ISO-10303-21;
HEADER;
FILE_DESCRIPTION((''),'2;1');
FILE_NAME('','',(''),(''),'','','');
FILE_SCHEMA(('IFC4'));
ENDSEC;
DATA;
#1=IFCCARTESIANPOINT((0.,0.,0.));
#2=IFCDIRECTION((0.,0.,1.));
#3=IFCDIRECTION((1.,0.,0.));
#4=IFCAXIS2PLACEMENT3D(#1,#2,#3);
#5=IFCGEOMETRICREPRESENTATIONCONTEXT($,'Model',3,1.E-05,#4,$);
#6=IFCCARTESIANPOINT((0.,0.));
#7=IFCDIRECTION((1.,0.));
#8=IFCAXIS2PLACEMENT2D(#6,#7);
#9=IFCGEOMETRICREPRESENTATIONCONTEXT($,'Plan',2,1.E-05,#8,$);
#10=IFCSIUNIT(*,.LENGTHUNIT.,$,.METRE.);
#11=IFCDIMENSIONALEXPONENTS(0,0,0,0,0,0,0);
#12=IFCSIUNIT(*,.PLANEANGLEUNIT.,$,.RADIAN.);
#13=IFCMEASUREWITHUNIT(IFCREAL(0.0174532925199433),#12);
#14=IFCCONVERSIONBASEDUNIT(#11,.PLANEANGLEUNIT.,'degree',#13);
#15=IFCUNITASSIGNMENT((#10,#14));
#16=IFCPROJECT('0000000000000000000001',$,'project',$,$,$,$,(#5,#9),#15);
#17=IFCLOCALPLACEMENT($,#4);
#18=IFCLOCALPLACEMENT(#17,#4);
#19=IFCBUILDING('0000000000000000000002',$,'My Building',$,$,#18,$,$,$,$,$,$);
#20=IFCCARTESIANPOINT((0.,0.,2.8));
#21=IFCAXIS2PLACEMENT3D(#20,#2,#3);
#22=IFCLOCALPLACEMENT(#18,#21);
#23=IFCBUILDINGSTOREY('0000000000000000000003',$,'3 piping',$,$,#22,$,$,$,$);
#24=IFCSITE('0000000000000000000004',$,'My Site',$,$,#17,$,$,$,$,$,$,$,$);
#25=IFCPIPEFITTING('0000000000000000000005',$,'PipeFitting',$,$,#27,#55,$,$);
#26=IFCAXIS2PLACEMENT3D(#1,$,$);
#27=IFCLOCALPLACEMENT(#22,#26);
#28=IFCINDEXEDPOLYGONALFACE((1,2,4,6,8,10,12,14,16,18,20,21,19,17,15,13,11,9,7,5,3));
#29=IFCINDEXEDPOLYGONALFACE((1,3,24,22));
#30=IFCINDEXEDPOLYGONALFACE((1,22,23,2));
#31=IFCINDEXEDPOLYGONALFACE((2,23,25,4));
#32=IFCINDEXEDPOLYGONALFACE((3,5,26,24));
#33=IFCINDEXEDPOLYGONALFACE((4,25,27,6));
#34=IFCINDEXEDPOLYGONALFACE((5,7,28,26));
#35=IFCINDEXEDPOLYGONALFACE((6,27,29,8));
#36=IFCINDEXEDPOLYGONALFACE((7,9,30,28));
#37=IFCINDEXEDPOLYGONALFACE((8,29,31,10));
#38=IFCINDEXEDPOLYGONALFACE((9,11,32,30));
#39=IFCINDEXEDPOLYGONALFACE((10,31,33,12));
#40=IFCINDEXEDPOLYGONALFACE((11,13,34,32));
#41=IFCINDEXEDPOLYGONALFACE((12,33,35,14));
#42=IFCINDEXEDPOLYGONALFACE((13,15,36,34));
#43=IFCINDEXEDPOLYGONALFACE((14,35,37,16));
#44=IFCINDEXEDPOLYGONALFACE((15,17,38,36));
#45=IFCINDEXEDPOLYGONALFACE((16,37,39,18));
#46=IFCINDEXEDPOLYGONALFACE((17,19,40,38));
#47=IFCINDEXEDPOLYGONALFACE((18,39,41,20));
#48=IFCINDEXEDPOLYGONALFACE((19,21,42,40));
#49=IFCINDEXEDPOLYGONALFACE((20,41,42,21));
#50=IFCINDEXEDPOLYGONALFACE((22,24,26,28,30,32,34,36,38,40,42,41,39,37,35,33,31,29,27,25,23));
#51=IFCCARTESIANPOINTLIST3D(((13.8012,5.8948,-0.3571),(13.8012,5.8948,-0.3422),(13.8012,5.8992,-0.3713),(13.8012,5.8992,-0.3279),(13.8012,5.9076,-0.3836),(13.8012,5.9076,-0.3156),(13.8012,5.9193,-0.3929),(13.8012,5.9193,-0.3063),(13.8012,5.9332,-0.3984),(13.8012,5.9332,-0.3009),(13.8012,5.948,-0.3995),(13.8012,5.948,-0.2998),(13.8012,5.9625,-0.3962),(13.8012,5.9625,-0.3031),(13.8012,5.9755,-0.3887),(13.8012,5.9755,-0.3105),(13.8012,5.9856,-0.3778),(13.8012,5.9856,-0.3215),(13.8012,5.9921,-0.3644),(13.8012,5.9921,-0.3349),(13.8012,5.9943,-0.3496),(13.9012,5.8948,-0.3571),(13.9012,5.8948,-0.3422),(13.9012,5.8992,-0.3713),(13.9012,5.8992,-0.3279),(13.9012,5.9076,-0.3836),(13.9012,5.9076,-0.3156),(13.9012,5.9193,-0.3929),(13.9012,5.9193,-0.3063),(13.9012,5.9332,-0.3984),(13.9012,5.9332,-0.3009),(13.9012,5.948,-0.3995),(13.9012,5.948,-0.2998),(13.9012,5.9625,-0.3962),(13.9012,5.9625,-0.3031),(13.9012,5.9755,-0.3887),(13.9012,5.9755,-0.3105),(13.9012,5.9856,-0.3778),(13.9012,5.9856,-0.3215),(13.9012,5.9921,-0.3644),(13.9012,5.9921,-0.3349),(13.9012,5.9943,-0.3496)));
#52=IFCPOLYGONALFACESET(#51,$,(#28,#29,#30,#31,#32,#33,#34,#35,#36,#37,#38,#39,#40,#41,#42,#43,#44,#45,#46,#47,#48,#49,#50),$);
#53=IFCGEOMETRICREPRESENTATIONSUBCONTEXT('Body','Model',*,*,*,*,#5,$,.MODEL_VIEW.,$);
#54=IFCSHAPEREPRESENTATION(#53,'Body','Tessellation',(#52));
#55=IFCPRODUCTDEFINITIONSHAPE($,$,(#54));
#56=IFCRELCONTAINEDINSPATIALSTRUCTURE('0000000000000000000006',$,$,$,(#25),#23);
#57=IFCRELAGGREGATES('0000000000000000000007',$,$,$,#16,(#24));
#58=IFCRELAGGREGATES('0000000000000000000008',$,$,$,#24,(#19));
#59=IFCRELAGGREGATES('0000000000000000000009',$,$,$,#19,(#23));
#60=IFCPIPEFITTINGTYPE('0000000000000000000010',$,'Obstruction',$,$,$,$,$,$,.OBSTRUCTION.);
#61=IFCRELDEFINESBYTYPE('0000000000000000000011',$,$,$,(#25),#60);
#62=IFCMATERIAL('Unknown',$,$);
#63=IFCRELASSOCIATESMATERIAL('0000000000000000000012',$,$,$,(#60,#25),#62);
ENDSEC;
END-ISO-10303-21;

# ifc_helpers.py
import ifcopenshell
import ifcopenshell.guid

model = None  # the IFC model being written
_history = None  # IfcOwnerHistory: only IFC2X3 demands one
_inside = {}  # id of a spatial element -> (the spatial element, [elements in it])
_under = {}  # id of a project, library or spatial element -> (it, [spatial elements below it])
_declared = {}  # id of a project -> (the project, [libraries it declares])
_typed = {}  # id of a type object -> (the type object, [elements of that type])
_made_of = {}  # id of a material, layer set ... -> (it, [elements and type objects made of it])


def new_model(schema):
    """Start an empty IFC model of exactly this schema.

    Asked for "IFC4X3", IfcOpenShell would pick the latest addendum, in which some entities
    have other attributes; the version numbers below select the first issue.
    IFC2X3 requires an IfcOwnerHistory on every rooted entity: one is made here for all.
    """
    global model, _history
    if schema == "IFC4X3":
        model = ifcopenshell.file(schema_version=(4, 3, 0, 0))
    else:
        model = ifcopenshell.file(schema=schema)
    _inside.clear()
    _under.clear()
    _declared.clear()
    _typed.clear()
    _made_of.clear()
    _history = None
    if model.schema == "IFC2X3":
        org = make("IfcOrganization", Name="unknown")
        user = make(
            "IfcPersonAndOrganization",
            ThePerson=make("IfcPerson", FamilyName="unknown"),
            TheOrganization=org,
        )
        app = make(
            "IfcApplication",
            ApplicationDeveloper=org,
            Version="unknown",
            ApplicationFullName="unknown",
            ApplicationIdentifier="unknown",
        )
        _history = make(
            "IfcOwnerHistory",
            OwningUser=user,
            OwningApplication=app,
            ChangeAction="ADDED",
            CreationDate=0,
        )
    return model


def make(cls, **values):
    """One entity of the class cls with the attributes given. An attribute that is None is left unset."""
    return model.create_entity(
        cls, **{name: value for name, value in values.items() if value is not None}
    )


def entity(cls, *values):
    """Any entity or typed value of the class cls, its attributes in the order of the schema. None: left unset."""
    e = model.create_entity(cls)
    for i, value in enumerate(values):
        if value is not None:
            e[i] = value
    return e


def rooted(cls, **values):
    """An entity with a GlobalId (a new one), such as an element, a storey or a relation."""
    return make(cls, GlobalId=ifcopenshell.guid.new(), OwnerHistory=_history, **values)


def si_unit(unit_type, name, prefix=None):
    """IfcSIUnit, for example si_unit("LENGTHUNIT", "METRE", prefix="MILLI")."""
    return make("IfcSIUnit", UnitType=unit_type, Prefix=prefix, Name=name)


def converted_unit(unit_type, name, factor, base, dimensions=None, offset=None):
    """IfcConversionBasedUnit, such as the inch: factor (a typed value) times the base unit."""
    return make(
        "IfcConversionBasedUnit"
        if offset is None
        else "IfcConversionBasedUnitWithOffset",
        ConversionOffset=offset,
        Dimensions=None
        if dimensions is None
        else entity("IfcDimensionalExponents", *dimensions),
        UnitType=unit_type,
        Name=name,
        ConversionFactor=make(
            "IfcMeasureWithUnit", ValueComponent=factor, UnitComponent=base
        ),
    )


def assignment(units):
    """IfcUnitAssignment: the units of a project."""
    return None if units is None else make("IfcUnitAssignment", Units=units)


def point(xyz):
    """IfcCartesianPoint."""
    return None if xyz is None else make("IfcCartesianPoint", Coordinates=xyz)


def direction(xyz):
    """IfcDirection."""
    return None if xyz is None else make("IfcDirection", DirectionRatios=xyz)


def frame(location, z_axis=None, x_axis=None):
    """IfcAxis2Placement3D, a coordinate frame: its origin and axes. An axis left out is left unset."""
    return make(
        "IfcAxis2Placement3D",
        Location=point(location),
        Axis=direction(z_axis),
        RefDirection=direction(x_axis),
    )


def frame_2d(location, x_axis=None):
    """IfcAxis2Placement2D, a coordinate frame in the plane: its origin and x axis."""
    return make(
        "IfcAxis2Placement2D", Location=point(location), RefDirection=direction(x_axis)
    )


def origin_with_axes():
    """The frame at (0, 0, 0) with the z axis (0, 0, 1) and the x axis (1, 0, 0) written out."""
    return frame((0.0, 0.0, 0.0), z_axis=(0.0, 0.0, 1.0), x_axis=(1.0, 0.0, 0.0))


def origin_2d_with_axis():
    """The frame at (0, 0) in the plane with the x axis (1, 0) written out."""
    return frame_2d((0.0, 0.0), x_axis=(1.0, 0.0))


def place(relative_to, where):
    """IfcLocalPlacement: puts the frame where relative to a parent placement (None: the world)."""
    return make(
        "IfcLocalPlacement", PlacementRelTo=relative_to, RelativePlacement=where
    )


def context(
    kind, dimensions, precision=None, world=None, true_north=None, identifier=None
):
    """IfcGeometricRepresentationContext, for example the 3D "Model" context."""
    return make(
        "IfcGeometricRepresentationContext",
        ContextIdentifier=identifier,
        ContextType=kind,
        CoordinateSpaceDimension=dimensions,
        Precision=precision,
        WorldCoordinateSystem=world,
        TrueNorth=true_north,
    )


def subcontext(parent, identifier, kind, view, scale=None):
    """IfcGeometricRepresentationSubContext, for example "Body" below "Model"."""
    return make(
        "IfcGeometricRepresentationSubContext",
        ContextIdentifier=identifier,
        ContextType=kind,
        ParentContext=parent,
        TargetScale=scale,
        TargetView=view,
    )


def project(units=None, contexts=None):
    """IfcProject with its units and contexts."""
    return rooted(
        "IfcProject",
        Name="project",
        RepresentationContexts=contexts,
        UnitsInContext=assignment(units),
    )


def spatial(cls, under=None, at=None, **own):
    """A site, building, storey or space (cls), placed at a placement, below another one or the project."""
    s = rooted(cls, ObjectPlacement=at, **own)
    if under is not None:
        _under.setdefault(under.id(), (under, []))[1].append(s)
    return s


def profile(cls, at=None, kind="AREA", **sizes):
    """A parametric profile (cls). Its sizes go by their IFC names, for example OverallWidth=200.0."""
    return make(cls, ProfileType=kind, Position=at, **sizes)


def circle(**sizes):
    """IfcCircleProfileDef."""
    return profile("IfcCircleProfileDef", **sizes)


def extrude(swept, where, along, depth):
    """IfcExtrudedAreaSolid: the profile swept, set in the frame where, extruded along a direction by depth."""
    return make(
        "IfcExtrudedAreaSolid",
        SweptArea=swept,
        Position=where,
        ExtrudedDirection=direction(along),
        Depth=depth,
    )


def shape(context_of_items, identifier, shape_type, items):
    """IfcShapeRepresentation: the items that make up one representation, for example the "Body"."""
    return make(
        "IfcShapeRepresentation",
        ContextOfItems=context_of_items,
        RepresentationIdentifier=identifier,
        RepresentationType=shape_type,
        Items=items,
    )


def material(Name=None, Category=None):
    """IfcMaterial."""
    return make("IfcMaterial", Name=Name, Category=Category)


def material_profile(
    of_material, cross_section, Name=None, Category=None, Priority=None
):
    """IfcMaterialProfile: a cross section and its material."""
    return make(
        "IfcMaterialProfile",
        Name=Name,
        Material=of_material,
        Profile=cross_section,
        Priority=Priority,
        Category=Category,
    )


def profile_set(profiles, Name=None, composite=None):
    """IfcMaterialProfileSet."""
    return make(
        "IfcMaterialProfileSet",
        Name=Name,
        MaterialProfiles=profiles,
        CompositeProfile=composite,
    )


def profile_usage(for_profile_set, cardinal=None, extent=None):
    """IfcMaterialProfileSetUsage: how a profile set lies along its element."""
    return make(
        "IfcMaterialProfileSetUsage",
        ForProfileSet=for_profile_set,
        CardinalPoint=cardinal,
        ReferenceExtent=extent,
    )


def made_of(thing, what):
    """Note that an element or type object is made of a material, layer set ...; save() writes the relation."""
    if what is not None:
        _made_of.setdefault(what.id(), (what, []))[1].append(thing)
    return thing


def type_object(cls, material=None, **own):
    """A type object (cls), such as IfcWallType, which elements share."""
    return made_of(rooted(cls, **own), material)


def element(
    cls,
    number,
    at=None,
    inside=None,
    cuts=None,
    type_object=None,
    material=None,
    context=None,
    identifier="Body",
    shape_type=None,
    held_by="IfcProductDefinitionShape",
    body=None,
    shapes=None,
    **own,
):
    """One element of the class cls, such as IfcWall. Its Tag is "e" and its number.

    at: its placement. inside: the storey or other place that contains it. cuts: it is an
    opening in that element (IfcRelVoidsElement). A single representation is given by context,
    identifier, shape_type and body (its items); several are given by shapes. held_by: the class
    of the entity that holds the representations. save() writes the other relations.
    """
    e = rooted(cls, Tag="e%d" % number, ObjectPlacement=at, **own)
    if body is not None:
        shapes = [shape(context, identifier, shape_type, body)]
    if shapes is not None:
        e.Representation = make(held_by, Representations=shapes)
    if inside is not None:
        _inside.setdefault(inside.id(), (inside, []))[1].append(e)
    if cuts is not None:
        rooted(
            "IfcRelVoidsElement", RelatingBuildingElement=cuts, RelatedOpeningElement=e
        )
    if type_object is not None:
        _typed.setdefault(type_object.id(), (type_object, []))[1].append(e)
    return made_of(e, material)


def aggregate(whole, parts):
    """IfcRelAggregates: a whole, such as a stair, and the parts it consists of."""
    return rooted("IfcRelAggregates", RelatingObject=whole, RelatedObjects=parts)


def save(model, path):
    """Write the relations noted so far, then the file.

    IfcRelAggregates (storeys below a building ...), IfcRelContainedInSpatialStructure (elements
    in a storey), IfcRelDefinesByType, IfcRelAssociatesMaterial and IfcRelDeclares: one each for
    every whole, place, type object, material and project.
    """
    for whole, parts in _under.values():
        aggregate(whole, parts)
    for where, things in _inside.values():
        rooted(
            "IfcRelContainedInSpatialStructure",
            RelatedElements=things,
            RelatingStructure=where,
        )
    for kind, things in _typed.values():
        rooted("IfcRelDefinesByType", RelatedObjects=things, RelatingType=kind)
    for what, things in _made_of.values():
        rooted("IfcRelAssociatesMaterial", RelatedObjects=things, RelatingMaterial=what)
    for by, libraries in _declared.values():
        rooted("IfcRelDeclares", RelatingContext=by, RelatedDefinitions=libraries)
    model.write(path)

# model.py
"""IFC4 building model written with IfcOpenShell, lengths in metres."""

from ifc_helpers import new_model, entity, si_unit, converted_unit, frame, origin_with_axes, origin_2d_with_axis, place, context, subcontext, project, spatial, circle, extrude, material, material_profile, profile_set, profile_usage, type_object, element, save


model = new_model("IFC4")

# Units and contexts
model_context = context("Model", 3, precision=1e-05, world=origin_with_axes())
plan_context = context("Plan", 2, precision=1e-05, world=origin_2d_with_axis())
body_context = subcontext(model_context, "Body", "Model", "MODEL_VIEW")
ifc_project = project(units=[si_unit("LENGTHUNIT", "METRE"), converted_unit("PLANEANGLEUNIT", "degree", entity("IfcReal", 0.0174532925199433), si_unit("PLANEANGLEUNIT", "RADIAN"), dimensions=[0, 0, 0, 0, 0, 0, 0])], contexts=[model_context, plan_context])

# Site, building, storey
site_placement = place(None, origin_with_axes())
site = spatial("IfcSite", under=ifc_project, at=site_placement, Name="My Site")
building_placement = place(site_placement, origin_with_axes())
building = spatial("IfcBuilding", under=site, at=building_placement, Name="My Building")
storey_placement = place(building_placement, frame((0.0, 0.0, 2.8), z_axis=(0.0, 0.0, 1.0), x_axis=(1.0, 0.0, 0.0)))
storey = spatial("IfcBuildingStorey", under=building, at=storey_placement, Name="3 piping")

# Shared definitions
ifc_material = material(Name="Unknown")

# Pipe fitting
ifc_material_profile_1 = material_profile(ifc_material, circle(Radius=0.05))
ifc_profile_set_1 = profile_set([ifc_material_profile_1])
ifc_profile_usage_1 = profile_usage(ifc_profile_set_1, cardinal=5)
pipe_fitting_type_1 = type_object("IfcPipeFittingType", Name="Obstruction", PredefinedType="OBSTRUCTION", material=ifc_profile_set_1)
pipe_fitting_1_placement = place(storey_placement, frame((13.8012, 5.9443, -0.3496), z_axis=(1.0, 0.0, 0.0), x_axis=(0.0, 1.0, 0.0)))
element("IfcPipeFitting", 1, at=pipe_fitting_1_placement, inside=storey, type_object=pipe_fitting_type_1, material=ifc_profile_usage_1, Name="PipeFitting", context=body_context, shape_type="SweptSolid", body=[
    extrude(circle(Radius=0.05), origin_with_axes(), (0.0, 0.0, 1.0), 0.1),
])

save(model, "model.ifc")
